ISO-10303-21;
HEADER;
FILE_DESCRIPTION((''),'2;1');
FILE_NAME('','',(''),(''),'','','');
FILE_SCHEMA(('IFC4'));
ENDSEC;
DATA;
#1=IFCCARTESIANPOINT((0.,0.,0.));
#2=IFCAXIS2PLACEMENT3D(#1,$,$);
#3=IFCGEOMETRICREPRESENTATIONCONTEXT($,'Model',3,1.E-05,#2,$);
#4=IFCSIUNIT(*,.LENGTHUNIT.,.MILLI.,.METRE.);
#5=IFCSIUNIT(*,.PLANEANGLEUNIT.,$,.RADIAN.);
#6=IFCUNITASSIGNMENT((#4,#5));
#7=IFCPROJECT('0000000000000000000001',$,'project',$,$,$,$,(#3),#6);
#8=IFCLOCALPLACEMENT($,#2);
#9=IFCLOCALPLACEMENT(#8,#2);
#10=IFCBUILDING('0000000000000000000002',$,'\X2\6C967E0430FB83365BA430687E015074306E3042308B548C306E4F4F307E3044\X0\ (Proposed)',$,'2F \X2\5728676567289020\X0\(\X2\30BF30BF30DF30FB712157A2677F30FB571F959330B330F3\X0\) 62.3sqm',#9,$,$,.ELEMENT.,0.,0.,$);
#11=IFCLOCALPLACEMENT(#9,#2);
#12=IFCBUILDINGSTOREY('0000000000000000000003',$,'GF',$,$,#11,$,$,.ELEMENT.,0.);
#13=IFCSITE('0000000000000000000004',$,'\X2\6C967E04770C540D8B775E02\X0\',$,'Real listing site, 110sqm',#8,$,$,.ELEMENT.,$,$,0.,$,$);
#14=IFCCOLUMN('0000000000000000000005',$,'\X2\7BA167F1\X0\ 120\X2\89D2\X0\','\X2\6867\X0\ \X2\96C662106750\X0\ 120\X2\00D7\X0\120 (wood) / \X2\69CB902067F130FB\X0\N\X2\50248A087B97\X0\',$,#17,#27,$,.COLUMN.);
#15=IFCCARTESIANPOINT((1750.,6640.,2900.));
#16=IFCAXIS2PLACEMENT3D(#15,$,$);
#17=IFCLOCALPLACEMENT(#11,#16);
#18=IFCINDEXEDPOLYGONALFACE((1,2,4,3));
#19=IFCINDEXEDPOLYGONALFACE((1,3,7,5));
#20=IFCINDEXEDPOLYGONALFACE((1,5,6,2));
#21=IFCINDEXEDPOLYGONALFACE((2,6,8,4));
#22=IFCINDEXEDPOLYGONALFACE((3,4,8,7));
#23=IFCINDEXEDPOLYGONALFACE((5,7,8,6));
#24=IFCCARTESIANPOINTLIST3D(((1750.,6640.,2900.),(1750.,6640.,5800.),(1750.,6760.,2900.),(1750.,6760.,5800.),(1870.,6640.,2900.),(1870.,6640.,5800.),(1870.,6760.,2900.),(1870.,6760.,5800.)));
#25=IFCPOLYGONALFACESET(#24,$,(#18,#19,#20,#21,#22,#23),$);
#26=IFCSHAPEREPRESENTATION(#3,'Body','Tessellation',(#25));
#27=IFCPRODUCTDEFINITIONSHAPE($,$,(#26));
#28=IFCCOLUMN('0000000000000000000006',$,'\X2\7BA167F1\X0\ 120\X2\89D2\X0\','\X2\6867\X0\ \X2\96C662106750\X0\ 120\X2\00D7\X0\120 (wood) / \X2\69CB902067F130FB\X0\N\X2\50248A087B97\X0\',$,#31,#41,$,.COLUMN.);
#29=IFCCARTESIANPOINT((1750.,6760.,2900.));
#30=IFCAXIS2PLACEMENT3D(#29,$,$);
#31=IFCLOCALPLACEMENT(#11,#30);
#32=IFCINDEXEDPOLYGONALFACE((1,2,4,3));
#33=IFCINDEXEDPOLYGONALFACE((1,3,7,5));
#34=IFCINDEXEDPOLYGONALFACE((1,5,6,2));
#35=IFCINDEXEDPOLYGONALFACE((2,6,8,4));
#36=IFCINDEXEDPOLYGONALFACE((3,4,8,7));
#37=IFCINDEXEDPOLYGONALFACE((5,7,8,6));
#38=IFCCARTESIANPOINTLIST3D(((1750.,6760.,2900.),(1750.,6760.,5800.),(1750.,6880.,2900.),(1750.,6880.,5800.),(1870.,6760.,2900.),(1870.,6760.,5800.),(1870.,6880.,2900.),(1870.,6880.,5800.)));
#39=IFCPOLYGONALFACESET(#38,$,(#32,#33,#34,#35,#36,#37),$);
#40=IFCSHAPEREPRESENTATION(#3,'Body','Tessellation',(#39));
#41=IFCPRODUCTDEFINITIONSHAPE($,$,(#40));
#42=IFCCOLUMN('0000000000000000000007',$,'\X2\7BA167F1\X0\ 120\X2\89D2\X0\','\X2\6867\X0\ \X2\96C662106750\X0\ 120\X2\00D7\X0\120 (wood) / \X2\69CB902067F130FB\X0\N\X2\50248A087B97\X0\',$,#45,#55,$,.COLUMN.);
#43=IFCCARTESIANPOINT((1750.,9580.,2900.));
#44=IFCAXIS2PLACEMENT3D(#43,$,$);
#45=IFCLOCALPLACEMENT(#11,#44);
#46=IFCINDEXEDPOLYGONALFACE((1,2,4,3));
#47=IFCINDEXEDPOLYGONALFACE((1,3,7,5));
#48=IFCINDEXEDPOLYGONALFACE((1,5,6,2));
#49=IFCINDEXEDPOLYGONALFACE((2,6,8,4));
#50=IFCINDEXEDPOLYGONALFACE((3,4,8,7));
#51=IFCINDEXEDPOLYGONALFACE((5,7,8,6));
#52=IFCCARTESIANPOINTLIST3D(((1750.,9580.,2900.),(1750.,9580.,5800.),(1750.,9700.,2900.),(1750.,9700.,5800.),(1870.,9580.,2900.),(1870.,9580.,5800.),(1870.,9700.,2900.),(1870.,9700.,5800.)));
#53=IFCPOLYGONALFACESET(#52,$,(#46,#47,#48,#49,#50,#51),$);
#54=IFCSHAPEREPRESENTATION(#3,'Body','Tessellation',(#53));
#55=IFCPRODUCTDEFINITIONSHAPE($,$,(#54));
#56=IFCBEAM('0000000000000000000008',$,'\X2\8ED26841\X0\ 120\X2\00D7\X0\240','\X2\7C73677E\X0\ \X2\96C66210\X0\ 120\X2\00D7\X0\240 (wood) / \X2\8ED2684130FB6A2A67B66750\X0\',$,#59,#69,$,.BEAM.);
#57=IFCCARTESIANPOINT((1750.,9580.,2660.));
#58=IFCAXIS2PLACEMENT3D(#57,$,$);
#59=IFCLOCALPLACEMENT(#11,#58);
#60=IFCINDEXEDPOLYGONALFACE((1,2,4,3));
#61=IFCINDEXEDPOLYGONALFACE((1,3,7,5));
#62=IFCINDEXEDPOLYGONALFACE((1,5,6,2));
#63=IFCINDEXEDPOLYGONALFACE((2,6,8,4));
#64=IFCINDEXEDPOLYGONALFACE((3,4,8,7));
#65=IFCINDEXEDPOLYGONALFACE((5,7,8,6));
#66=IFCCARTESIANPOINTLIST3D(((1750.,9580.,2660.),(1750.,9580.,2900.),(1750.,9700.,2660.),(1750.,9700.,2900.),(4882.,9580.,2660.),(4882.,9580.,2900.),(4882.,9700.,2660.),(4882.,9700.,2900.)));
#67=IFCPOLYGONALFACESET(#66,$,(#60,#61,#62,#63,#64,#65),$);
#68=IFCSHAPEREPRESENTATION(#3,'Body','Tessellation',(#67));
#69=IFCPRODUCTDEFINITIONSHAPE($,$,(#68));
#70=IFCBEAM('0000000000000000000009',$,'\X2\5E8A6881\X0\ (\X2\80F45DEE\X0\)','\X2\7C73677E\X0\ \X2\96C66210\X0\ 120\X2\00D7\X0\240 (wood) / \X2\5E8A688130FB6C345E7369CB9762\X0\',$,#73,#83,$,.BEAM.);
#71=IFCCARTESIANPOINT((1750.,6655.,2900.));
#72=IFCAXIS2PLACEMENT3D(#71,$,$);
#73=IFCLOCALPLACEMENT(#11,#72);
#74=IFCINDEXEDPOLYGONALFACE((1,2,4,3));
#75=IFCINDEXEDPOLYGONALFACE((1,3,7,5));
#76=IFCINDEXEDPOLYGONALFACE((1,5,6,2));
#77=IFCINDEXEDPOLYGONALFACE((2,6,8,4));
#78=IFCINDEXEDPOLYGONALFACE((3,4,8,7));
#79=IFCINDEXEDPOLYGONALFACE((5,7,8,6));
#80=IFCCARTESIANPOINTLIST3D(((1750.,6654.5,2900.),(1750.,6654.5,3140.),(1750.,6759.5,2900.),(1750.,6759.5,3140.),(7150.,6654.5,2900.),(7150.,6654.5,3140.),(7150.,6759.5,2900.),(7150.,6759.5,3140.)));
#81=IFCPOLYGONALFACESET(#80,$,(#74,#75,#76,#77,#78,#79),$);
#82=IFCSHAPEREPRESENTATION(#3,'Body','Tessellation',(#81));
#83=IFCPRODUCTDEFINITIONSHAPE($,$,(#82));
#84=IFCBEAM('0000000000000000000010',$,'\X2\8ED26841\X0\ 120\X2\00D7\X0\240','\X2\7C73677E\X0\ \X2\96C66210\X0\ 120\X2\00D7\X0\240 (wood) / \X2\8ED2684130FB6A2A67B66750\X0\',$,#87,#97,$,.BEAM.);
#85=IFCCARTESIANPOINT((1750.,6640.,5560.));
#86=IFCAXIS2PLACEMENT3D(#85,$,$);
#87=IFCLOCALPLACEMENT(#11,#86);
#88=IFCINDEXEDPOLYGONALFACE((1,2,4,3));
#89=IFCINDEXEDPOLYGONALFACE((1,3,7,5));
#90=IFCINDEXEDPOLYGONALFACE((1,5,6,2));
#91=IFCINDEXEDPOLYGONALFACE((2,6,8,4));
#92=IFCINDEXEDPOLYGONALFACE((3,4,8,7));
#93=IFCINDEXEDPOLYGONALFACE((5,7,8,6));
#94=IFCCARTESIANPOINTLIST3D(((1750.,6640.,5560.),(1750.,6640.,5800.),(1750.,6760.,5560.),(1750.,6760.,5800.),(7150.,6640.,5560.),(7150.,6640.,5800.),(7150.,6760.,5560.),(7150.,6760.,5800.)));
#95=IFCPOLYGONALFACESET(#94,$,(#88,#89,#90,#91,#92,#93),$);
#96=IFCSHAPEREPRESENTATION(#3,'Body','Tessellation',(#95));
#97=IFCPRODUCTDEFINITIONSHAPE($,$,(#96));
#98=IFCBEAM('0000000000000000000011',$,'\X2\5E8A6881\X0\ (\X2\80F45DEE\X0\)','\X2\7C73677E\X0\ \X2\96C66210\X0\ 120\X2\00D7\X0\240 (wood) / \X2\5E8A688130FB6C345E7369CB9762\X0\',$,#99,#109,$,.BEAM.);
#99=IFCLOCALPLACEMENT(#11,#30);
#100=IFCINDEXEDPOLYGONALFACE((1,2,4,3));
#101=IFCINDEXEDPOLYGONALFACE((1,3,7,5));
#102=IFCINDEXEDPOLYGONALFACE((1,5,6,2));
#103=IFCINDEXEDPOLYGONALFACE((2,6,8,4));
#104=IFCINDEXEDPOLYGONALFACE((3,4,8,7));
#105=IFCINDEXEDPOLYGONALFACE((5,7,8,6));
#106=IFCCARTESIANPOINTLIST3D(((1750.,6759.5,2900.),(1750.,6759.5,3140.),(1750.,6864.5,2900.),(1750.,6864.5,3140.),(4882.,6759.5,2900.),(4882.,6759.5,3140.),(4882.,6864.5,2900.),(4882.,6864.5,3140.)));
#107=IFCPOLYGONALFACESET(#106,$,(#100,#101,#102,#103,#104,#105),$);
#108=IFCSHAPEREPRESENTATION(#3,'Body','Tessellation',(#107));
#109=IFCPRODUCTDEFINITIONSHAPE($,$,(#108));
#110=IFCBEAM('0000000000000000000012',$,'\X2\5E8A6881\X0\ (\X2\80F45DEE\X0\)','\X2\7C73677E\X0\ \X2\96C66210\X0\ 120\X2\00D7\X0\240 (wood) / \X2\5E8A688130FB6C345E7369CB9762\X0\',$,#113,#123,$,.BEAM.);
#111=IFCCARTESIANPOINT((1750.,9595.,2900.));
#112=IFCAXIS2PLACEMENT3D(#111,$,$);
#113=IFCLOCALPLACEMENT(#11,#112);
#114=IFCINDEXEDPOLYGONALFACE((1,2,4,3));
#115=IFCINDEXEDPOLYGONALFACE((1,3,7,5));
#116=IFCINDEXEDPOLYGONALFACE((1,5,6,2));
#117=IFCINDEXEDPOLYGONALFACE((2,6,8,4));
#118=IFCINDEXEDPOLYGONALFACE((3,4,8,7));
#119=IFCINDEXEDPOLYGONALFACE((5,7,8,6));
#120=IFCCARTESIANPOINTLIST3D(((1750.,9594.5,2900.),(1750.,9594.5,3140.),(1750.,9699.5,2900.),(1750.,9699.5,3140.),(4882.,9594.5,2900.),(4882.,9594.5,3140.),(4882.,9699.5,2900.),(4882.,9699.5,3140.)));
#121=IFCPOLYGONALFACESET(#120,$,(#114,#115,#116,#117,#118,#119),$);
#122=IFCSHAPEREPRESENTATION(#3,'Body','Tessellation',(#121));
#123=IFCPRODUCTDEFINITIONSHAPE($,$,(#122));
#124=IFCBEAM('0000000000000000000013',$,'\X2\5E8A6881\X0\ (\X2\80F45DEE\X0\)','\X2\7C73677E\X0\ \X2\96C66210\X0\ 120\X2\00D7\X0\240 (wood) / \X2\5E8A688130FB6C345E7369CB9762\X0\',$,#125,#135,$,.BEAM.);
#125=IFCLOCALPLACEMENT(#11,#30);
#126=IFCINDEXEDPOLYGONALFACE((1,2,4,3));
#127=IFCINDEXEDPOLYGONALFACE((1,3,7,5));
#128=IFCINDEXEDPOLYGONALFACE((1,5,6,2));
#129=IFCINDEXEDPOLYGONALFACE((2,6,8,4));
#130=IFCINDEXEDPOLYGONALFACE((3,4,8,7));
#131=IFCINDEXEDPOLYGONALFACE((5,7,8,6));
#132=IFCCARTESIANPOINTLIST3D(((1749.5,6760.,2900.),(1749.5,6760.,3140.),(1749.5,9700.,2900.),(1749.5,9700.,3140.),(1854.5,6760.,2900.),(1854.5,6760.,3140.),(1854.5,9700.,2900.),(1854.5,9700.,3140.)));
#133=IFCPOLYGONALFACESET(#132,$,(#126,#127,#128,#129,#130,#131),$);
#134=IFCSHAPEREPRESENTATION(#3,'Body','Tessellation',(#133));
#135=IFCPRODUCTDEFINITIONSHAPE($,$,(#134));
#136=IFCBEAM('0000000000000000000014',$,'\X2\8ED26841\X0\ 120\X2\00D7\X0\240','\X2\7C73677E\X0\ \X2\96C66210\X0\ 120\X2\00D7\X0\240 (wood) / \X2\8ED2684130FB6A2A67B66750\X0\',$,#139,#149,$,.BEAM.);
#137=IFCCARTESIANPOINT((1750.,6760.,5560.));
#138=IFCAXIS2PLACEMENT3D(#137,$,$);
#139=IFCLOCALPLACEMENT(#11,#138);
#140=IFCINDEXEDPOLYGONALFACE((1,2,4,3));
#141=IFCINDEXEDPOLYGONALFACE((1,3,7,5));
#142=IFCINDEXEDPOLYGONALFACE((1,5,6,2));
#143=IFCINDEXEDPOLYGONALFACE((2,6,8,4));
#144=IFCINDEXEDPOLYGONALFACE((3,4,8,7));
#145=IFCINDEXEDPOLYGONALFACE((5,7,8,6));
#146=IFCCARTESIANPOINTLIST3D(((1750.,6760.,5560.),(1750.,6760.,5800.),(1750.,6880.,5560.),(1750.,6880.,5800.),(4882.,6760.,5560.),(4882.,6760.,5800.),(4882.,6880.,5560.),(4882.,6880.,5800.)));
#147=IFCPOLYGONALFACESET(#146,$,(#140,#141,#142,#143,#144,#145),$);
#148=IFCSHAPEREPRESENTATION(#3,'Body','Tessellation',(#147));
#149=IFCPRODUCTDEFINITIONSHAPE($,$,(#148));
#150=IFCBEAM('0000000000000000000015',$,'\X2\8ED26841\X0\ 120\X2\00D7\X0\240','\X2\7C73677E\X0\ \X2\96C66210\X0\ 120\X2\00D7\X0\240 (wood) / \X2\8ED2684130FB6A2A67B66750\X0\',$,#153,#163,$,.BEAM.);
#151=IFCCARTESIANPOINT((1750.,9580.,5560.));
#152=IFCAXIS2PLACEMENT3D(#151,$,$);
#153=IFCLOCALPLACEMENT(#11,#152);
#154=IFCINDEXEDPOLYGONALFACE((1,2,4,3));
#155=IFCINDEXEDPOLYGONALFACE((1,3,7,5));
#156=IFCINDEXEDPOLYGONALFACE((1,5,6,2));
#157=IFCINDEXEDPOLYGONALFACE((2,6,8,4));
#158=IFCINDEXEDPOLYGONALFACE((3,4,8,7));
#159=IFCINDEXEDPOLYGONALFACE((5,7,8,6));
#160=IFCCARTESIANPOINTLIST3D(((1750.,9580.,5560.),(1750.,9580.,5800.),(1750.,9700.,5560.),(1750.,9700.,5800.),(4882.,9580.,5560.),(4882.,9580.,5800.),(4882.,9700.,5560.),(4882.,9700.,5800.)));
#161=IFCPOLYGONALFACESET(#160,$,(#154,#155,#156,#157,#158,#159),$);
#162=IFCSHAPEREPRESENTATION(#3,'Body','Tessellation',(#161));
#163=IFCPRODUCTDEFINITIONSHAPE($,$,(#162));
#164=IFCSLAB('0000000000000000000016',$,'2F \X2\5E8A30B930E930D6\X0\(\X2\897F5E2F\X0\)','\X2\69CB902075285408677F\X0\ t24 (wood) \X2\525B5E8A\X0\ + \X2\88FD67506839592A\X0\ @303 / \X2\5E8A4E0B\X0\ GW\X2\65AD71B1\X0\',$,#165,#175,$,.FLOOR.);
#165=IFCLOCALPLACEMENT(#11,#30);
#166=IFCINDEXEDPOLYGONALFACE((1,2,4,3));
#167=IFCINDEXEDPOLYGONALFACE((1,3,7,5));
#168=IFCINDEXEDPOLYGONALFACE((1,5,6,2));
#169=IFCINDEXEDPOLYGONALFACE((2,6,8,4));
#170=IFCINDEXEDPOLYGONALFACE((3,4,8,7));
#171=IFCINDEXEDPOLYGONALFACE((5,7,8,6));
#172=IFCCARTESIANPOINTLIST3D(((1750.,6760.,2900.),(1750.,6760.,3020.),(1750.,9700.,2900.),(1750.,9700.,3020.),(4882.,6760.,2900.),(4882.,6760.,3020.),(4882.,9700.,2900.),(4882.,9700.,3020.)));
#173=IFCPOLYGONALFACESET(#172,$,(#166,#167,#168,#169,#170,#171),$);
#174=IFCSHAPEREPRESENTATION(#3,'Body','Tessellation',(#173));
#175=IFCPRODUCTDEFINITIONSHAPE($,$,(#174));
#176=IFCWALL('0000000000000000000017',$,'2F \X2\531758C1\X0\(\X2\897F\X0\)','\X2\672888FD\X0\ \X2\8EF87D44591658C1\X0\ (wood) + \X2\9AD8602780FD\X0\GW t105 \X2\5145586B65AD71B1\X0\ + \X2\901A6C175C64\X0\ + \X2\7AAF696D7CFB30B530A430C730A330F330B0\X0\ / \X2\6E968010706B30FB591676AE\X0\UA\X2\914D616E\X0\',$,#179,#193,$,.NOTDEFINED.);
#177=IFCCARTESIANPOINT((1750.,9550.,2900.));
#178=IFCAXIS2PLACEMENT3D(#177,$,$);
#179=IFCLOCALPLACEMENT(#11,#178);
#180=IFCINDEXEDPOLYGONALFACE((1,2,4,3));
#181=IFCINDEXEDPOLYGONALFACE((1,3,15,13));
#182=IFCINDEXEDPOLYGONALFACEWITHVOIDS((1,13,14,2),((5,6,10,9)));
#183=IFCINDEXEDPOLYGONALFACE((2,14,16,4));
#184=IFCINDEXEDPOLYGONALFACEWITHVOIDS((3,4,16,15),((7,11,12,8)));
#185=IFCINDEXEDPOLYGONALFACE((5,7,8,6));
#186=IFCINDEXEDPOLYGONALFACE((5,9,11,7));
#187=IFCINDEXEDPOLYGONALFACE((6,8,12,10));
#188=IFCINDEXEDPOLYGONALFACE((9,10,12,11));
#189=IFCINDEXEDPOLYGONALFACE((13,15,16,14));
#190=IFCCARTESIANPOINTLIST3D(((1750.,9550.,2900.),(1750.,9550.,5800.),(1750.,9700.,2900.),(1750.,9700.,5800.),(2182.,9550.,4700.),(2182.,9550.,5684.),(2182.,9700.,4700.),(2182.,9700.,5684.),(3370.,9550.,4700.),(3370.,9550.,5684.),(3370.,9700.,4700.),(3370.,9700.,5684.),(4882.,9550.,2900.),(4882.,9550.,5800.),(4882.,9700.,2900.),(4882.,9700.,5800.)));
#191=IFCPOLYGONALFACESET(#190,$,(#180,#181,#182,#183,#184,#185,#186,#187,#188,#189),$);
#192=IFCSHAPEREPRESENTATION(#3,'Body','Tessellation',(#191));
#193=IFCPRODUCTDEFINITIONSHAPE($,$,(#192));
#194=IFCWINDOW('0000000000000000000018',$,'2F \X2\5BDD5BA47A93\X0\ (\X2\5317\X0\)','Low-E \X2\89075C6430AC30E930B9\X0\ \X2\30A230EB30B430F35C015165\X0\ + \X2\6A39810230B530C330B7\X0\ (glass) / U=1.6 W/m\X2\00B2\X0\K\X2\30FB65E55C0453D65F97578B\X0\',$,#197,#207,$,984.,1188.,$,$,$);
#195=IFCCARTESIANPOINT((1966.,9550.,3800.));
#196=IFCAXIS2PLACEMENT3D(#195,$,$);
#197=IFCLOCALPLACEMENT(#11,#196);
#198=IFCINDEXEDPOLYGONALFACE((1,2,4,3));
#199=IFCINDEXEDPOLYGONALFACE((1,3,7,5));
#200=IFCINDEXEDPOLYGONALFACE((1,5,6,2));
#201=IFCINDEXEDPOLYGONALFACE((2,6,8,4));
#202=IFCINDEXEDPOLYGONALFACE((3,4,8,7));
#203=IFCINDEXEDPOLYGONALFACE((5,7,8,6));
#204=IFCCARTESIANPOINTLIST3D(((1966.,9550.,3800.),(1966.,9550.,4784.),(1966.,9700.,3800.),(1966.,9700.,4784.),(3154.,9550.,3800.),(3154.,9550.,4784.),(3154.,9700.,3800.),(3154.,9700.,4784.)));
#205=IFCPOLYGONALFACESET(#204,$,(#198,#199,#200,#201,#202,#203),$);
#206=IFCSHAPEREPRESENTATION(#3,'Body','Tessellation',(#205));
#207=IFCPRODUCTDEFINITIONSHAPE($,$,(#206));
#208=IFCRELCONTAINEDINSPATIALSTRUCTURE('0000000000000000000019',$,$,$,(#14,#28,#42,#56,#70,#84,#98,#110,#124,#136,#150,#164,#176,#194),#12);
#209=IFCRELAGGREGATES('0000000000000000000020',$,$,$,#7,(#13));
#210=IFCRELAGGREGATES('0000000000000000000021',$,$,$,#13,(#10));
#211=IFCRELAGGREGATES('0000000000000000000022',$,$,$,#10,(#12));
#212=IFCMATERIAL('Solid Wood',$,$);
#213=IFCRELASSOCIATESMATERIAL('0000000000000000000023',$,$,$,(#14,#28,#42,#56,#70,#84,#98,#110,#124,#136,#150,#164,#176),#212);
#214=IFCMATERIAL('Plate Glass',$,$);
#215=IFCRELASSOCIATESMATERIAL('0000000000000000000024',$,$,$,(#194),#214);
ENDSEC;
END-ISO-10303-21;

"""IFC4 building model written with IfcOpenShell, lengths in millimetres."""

from ifc_helpers import new_model, si_unit, frame, frame_2d, origin, place, context, project, spatial, rectangle, extrude, material, element, fill, save


model = new_model("IFC4")

# Units and contexts
model_context = context("Model", 3, precision=1e-05, world=origin())
ifc_project = project(units=[si_unit("LENGTHUNIT", "METRE", prefix="MILLI"), si_unit("PLANEANGLEUNIT", "RADIAN")], contexts=[model_context])

# Site, building, storey
site_placement = place(None, origin())
site = spatial("IfcSite", under=ifc_project, at=site_placement, Name="沖縄県名護市", ObjectType="Real listing site, 110sqm", CompositionType="ELEMENT", RefElevation=0.0)
building_placement = place(site_placement, origin())
building = spatial("IfcBuilding", under=site, at=building_placement, Name="沖縄・茶室と縁側のある和の住まい (Proposed)", ObjectType="2F 在来木造(タタミ・無垢板・土間コン) 62.3sqm", CompositionType="ELEMENT", ElevationOfRefHeight=0.0, ElevationOfTerrain=0.0)
storey_placement = place(building_placement, origin())
storey = spatial("IfcBuildingStorey", under=building, at=storey_placement, Name="GF", CompositionType="ELEMENT", Elevation=0.0)

# Columns
ifc_material_1 = material(Name="Solid Wood")
column_1_placement = place(storey_placement, frame((1750.0, 6640.0, 2900.0)))
element("IfcColumn", 1, at=column_1_placement, inside=storey, material=ifc_material_1, Name="管柱 120角", Description="桧 集成材 120×120 (wood) / 構造柱・N値計算", PredefinedType="COLUMN", context=model_context, shape_type="SweptSolid", body=[
    extrude(rectangle(XDim=120.0, YDim=120.0, at=frame_2d((60.0, 60.0))), frame((1750.0, 6640.0, 2900.0)), (0.0, 0.0, 1.0), 2900.0),
])
column_2_placement = place(storey_placement, frame((1750.0, 6760.0, 2900.0)))
element("IfcColumn", 2, at=column_2_placement, inside=storey, material=ifc_material_1, Name="管柱 120角", Description="桧 集成材 120×120 (wood) / 構造柱・N値計算", PredefinedType="COLUMN", context=model_context, shape_type="SweptSolid", body=[
    extrude(rectangle(XDim=120.0, YDim=120.0, at=frame_2d((60.0, 60.0))), frame((1750.0, 6760.0, 2900.0)), (0.0, 0.0, 1.0), 2900.0),
])
column_3_placement = place(storey_placement, frame((1750.0, 9580.0, 2900.0)))
element("IfcColumn", 3, at=column_3_placement, inside=storey, material=ifc_material_1, Name="管柱 120角", Description="桧 集成材 120×120 (wood) / 構造柱・N値計算", PredefinedType="COLUMN", context=model_context, shape_type="SweptSolid", body=[
    extrude(rectangle(XDim=120.0, YDim=120.0, at=frame_2d((60.0, 60.0))), frame((1750.0, 9580.0, 2900.0)), (0.0, 0.0, 1.0), 2900.0),
])

# Beams
beam_1_placement = place(storey_placement, frame((1750.0, 9580.0, 2660.0)))
element("IfcBeam", 4, at=beam_1_placement, inside=storey, material=ifc_material_1, Name="軒桁 120×240", Description="米松 集成 120×240 (wood) / 軒桁・横架材", PredefinedType="BEAM", context=model_context, shape_type="SweptSolid", body=[
    extrude(rectangle(XDim=3132.0, YDim=120.0, at=frame_2d((1566.0, 60.0))), frame((1750.0, 9580.0, 2660.0)), (0.0, 0.0, 1.0), 240.0),
])
beam_2_placement = place(storey_placement, frame((1750.0, 6655.0, 2900.0)))
element("IfcBeam", 5, at=beam_2_placement, inside=storey, material=ifc_material_1, Name="床梁 (胴差)", Description="米松 集成 120×240 (wood) / 床梁・水平構面", PredefinedType="BEAM", context=model_context, shape_type="SweptSolid", body=[
    extrude(rectangle(XDim=5400.0, YDim=105.0, at=frame_2d((2700.0, 52.0))), frame((1750.0, 6655.0, 2900.0)), (0.0, 0.0, 1.0), 240.0),
])
beam_3_placement = place(storey_placement, frame((1750.0, 6640.0, 5560.0)))
element("IfcBeam", 6, at=beam_3_placement, inside=storey, material=ifc_material_1, Name="軒桁 120×240", Description="米松 集成 120×240 (wood) / 軒桁・横架材", PredefinedType="BEAM", context=model_context, shape_type="SweptSolid", body=[
    extrude(rectangle(XDim=5400.0, YDim=120.0, at=frame_2d((2700.0, 60.0))), frame((1750.0, 6640.0, 5560.0)), (0.0, 0.0, 1.0), 240.0),
])
beam_4_placement = place(storey_placement, frame((1750.0, 6760.0, 2900.0)))
element("IfcBeam", 7, at=beam_4_placement, inside=storey, material=ifc_material_1, Name="床梁 (胴差)", Description="米松 集成 120×240 (wood) / 床梁・水平構面", PredefinedType="BEAM", context=model_context, shape_type="SweptSolid", body=[
    extrude(rectangle(XDim=3132.0, YDim=105.0, at=frame_2d((1566.0, 52.0))), frame((1750.0, 6760.0, 2900.0)), (0.0, 0.0, 1.0), 240.0),
])
beam_5_placement = place(storey_placement, frame((1750.0, 9595.0, 2900.0)))
element("IfcBeam", 8, at=beam_5_placement, inside=storey, material=ifc_material_1, Name="床梁 (胴差)", Description="米松 集成 120×240 (wood) / 床梁・水平構面", PredefinedType="BEAM", context=model_context, shape_type="SweptSolid", body=[
    extrude(rectangle(XDim=3132.0, YDim=105.0, at=frame_2d((1566.0, 52.0))), frame((1750.0, 9595.0, 2900.0)), (0.0, 0.0, 1.0), 240.0),
])
beam_6_placement = place(storey_placement, frame((1750.0, 6760.0, 2900.0)))
element("IfcBeam", 9, at=beam_6_placement, inside=storey, material=ifc_material_1, Name="床梁 (胴差)", Description="米松 集成 120×240 (wood) / 床梁・水平構面", PredefinedType="BEAM", context=model_context, shape_type="SweptSolid", body=[
    extrude(rectangle(XDim=105.0, YDim=2940.0, at=frame_2d((52.0, 1470.0))), frame((1750.0, 6760.0, 2900.0)), (0.0, 0.0, 1.0), 240.0),
])
beam_7_placement = place(storey_placement, frame((1750.0, 6760.0, 5560.0)))
element("IfcBeam", 10, at=beam_7_placement, inside=storey, material=ifc_material_1, Name="軒桁 120×240", Description="米松 集成 120×240 (wood) / 軒桁・横架材", PredefinedType="BEAM", context=model_context, shape_type="SweptSolid", body=[
    extrude(rectangle(XDim=3132.0, YDim=120.0, at=frame_2d((1566.0, 60.0))), frame((1750.0, 6760.0, 5560.0)), (0.0, 0.0, 1.0), 240.0),
])
beam_8_placement = place(storey_placement, frame((1750.0, 9580.0, 5560.0)))
element("IfcBeam", 11, at=beam_8_placement, inside=storey, material=ifc_material_1, Name="軒桁 120×240", Description="米松 集成 120×240 (wood) / 軒桁・横架材", PredefinedType="BEAM", context=model_context, shape_type="SweptSolid", body=[
    extrude(rectangle(XDim=3132.0, YDim=120.0, at=frame_2d((1566.0, 60.0))), frame((1750.0, 9580.0, 5560.0)), (0.0, 0.0, 1.0), 240.0),
])

# Slab
slab_placement = place(storey_placement, frame((1750.0, 6760.0, 2900.0)))
element("IfcSlab", 12, at=slab_placement, inside=storey, material=ifc_material_1, Name="2F 床スラブ(西帯)", Description="構造用合板 t24 (wood) 剛床 + 製材根太 @303 / 床下 GW断熱", PredefinedType="FLOOR", context=model_context, shape_type="SweptSolid", body=[
    extrude(rectangle(XDim=3132.0, YDim=2940.0, at=frame_2d((1566.0, 1470.0))), frame((1750.0, 6760.0, 2900.0)), (0.0, 0.0, 1.0), 120.0),
])

# Wall, opening, window
wall_1_placement = place(storey_placement, frame((1750.0, 9550.0, 2900.0)))
wall_1 = element("IfcWall", 13, at=wall_1_placement, inside=storey, material=ifc_material_1, Name="2F 北壁(西)", Description="木製 軸組外壁 (wood) + 高性能GW t105 充填断熱 + 通気層 + 窯業系サイディング / 準耐火・外皮UA配慮", PredefinedType="NOTDEFINED", context=model_context, shape_type="SweptSolid", body=[
    extrude(rectangle(XDim=3132.0, YDim=150.0, at=frame_2d((1566.0, 75.0))), frame((1750.0, 9550.0, 2900.0)), (0.0, 0.0, 1.0), 2900.0),
])
opening_placement = place(storey_placement, frame((1966.0, 9550.0, 3800.0)))
opening = element("IfcOpeningElement", 14, at=opening_placement, cuts=wall_1, PredefinedType="NOTDEFINED", context=model_context, shape_type="SweptSolid", body=[
    extrude(rectangle(XDim=1188.0, YDim=150.0, at=frame_2d((594.0, 75.0))), frame((1966.0, 9550.0, 3800.0)), (0.0, 0.0, 1.0), 984.0),
])
ifc_material_2 = material(Name="Plate Glass")
window_placement = place(storey_placement, frame((1966.0, 9550.0, 3800.0)))
window = element("IfcWindow", 15, at=window_placement, inside=storey, material=ifc_material_2, Name="2F 寝室窓 (北)", Description="Low-E 複層ガラス アルゴン封入 + 樹脂サッシ (glass) / U=1.6 W/m²K・日射取得型", OverallHeight=984.0, OverallWidth=1188.0, context=model_context, shape_type="SweptSolid", body=[
    extrude(rectangle(XDim=1188.0, YDim=150.0, at=frame_2d((594.0, 75.0))), frame((1966.0, 9550.0, 3800.0)), (0.0, 0.0, 1.0), 984.0),
])
fill(opening, window)

save(model, "model.ifc")
